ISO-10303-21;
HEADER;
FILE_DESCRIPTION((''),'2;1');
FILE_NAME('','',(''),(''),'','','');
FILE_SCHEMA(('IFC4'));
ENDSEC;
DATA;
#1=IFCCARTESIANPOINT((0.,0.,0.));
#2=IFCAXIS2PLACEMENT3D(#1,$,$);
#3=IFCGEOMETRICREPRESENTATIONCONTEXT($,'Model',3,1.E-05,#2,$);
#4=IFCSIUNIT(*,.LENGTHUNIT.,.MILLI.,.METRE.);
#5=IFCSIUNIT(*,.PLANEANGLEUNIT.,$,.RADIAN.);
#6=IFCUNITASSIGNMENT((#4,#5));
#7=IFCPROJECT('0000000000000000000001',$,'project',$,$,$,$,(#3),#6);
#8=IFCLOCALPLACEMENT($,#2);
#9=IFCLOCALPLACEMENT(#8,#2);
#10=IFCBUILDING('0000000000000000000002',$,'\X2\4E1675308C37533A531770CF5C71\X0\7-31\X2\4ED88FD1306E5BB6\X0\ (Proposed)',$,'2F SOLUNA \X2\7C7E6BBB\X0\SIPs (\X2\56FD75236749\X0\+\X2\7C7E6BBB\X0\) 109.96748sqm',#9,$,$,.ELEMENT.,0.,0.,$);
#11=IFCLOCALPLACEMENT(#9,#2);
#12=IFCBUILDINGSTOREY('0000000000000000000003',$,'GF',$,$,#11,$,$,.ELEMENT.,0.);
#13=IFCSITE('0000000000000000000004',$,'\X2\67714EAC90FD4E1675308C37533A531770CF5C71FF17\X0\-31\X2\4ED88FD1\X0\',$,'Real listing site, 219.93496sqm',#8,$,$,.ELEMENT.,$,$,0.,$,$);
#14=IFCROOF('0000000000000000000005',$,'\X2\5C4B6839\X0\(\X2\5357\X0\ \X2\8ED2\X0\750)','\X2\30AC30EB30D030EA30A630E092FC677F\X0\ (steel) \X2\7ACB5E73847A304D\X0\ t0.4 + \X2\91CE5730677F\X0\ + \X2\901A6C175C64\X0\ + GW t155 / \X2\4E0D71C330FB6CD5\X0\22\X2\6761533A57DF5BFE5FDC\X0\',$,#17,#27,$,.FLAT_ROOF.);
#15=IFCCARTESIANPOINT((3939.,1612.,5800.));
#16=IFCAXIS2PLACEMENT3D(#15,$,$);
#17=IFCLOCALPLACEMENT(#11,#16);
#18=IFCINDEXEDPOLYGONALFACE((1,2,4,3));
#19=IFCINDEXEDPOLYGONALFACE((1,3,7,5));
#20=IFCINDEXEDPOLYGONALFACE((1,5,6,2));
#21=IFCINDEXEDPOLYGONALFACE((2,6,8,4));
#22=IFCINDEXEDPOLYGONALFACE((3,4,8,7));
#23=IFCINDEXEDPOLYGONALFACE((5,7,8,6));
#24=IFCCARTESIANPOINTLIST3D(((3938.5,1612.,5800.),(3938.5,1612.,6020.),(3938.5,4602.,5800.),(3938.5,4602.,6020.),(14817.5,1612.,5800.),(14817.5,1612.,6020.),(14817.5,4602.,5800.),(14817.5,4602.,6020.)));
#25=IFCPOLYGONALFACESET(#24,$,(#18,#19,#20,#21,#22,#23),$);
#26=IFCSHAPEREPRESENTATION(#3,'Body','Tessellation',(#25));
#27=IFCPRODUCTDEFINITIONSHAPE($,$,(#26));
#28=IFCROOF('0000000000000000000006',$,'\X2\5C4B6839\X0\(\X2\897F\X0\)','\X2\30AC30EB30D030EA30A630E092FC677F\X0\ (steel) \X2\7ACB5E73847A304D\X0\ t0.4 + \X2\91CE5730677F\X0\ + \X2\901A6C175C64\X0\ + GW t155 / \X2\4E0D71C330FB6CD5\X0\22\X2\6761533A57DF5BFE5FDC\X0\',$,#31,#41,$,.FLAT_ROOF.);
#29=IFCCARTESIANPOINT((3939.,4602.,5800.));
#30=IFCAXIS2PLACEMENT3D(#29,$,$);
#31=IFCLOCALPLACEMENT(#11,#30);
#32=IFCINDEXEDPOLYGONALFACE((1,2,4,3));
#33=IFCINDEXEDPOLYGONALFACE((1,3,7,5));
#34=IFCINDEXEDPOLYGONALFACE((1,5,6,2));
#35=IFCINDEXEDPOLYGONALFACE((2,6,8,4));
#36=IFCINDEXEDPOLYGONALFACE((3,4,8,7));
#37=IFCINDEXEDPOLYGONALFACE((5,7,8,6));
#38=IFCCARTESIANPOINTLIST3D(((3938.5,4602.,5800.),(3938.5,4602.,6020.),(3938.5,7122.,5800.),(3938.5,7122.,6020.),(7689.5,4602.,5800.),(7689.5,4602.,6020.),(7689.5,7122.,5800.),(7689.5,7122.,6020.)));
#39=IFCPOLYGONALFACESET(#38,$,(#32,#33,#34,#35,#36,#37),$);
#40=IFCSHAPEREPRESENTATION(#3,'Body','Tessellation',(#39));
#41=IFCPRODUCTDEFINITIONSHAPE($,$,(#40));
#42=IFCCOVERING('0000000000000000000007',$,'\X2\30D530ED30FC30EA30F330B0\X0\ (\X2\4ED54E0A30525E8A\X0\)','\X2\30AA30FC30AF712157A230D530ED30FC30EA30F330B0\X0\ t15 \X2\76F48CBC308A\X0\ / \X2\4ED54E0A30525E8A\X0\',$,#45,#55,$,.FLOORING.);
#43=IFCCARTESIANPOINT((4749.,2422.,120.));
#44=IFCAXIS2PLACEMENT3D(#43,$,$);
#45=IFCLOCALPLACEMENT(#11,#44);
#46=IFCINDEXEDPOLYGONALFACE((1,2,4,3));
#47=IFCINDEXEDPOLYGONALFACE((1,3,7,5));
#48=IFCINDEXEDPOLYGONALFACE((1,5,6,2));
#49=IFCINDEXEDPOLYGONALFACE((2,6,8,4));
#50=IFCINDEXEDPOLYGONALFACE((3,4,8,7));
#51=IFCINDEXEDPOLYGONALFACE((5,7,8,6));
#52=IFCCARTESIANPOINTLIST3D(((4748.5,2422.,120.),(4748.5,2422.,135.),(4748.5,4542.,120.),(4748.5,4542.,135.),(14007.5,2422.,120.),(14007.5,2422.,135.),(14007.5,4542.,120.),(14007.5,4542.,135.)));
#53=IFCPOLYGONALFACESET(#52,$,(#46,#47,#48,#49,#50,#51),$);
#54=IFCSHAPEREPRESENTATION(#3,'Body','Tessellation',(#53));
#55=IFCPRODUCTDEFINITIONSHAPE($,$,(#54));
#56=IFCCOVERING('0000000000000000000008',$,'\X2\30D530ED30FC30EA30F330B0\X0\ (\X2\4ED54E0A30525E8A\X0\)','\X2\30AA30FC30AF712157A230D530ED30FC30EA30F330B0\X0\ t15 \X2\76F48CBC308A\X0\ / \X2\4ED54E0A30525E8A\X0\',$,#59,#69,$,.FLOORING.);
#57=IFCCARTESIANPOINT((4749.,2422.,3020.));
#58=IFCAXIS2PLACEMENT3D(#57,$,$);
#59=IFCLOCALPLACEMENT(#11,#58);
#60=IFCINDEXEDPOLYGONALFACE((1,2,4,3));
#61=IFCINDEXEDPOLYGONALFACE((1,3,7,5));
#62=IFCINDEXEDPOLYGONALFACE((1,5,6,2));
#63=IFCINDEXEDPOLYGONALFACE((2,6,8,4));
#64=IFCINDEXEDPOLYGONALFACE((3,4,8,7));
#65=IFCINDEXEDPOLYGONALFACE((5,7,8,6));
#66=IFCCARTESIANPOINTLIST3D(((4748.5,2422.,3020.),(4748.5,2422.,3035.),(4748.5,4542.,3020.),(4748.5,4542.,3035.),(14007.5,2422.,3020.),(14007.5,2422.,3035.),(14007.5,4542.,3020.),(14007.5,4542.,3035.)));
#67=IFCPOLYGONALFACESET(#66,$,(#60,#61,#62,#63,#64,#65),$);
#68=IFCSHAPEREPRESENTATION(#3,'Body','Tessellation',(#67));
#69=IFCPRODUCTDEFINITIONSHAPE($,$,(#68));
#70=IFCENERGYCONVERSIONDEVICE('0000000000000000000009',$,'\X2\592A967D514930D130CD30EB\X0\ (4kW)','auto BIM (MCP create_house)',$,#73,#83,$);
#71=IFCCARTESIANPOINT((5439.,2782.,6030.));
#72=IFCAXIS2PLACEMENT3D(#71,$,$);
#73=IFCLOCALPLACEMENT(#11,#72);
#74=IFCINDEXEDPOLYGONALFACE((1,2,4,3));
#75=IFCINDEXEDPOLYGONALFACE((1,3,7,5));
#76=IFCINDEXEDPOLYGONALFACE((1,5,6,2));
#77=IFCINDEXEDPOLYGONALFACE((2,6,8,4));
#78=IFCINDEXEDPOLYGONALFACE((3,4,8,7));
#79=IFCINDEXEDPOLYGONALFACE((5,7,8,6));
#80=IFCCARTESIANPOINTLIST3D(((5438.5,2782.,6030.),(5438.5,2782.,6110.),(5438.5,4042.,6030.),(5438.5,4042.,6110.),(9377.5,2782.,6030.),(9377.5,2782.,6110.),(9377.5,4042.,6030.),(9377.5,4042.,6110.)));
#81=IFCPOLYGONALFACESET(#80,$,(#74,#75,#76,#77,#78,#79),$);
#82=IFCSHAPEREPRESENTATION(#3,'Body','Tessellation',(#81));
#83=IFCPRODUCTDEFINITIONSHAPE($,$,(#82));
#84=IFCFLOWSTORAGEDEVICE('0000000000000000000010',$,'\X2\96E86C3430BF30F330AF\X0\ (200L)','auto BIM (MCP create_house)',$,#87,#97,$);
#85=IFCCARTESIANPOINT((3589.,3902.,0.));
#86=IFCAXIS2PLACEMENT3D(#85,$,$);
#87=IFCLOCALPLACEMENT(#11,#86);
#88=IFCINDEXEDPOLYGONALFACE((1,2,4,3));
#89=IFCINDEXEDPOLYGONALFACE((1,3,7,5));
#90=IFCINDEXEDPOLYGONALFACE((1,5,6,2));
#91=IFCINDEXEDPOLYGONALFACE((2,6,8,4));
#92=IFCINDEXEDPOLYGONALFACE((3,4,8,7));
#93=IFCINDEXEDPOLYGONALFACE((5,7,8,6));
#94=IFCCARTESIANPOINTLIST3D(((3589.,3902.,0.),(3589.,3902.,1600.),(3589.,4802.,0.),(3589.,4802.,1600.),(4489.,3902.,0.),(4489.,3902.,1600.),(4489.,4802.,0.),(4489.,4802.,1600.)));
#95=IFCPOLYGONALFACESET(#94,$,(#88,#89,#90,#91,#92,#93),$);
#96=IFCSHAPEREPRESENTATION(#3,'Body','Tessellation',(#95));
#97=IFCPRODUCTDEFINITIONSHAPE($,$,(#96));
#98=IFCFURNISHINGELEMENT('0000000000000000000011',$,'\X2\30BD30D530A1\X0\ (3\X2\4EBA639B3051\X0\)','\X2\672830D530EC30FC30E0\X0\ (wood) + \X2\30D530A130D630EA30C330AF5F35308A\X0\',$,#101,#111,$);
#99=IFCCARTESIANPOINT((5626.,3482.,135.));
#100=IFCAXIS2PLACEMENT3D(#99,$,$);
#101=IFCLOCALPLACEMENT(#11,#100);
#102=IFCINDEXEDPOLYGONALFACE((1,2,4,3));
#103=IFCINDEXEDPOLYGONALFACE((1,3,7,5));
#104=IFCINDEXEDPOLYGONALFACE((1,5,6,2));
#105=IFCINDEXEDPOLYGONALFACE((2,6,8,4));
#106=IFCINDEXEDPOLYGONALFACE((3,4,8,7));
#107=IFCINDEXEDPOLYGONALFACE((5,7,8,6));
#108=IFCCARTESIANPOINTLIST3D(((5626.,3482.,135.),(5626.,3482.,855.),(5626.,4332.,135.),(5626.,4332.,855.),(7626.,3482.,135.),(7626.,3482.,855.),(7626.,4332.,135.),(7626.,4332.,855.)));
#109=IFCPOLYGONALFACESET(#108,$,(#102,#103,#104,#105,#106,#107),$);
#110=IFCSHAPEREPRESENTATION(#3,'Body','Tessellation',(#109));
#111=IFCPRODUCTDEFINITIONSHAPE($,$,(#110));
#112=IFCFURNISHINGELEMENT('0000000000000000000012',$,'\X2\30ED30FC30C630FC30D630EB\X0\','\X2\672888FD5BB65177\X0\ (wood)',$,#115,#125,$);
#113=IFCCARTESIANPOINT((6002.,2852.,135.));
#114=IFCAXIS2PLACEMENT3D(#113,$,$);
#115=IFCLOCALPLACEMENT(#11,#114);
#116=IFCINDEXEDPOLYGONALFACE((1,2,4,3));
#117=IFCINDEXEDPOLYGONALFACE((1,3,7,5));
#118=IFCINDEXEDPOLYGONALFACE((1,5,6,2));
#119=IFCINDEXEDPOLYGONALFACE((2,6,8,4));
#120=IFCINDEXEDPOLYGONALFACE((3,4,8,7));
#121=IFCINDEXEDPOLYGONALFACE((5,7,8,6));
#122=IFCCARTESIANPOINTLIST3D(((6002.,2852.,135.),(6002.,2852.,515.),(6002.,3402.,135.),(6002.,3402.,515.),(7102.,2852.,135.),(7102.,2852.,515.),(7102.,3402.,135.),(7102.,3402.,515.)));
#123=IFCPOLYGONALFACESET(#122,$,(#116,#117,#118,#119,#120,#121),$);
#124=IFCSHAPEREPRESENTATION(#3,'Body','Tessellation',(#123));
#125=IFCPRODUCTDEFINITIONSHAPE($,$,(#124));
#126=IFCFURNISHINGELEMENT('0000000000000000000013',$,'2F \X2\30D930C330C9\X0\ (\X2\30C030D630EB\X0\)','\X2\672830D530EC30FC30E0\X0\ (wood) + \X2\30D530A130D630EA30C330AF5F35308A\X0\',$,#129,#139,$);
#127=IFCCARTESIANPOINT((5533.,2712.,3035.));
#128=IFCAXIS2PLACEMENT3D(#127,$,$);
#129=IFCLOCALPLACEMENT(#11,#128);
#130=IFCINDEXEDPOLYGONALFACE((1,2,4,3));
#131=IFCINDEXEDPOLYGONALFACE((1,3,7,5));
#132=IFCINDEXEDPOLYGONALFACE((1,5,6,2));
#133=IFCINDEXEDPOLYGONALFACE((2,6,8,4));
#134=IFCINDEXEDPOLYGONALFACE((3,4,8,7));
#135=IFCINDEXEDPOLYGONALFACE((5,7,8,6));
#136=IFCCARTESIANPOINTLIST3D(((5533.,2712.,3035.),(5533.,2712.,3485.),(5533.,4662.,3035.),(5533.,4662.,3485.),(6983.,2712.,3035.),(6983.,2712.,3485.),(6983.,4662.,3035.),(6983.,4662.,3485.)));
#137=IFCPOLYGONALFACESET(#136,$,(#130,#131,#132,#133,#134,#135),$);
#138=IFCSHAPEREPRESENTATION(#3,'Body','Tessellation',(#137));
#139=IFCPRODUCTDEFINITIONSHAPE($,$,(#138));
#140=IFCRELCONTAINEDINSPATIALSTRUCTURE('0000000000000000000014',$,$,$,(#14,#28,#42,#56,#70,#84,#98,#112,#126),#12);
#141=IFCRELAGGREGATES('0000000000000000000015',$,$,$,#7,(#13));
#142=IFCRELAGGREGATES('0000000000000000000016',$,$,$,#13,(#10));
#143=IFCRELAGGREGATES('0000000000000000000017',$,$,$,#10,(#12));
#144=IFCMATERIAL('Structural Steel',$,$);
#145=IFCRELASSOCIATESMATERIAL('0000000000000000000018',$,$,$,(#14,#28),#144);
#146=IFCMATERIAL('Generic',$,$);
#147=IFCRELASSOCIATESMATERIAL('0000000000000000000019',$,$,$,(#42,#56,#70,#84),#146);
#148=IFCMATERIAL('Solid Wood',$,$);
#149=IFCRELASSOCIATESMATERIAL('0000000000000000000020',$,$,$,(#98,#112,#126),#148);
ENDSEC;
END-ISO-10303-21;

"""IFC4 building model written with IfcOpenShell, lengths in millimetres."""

from ifc_helpers import new_model, si_unit, frame, frame_2d, origin, place, context, project, spatial, rectangle, extrude, material, element, save


model = new_model("IFC4")

# Units and contexts
model_context = context("Model", 3, precision=1e-05, world=origin())
ifc_project = project(units=[si_unit("LENGTHUNIT", "METRE", prefix="MILLI"), si_unit("PLANEANGLEUNIT", "RADIAN")], contexts=[model_context])

# Site, building, storey
site_placement = place(None, origin())
site = spatial("IfcSite", under=ifc_project, at=site_placement, Name="東京都世田谷区北烏山７-31付近", ObjectType="Real listing site, 219.93496sqm", CompositionType="ELEMENT", RefElevation=0.0)
building_placement = place(site_placement, origin())
building = spatial("IfcBuilding", under=site, at=building_placement, Name="世田谷区北烏山7-31付近の家 (Proposed)", ObjectType="2F SOLUNA 籾殻SIPs (国産杉+籾殻) 109.96748sqm", CompositionType="ELEMENT", ElevationOfRefHeight=0.0, ElevationOfTerrain=0.0)
storey_placement = place(building_placement, origin())
storey = spatial("IfcBuildingStorey", under=building, at=storey_placement, Name="GF", CompositionType="ELEMENT", Elevation=0.0)

# Shared definitions
ifc_material_1 = material(Name="Solid Wood")

# Roofs
ifc_material_2 = material(Name="Structural Steel")
roof_1_placement = place(storey_placement, frame((3939.0, 1612.0, 5800.0)))
element("IfcRoof", 1, at=roof_1_placement, inside=storey, material=ifc_material_2, Name="屋根(南 軒750)", Description="ガルバリウム鋼板 (steel) 立平葺き t0.4 + 野地板 + 通気層 + GW t155 / 不燃・法22条区域対応", PredefinedType="FLAT_ROOF", context=model_context, shape_type="SweptSolid", body=[
    extrude(rectangle(XDim=10879.0, YDim=2990.0, at=frame_2d((5439.0, 1495.0))), frame((3939.0, 1612.0, 5800.0)), (0.0, 0.0, 1.0), 220.0),
])
roof_2_placement = place(storey_placement, frame((3939.0, 4602.0, 5800.0)))
element("IfcRoof", 2, at=roof_2_placement, inside=storey, material=ifc_material_2, Name="屋根(西)", Description="ガルバリウム鋼板 (steel) 立平葺き t0.4 + 野地板 + 通気層 + GW t155 / 不燃・法22条区域対応", PredefinedType="FLAT_ROOF", context=model_context, shape_type="SweptSolid", body=[
    extrude(rectangle(XDim=3751.0, YDim=2520.0, at=frame_2d((1875.0, 1260.0))), frame((3939.0, 4602.0, 5800.0)), (0.0, 0.0, 1.0), 220.0),
])

# Coverings
ifc_material_3 = material(Name="Generic")
covering_1_placement = place(storey_placement, frame((4749.0, 2422.0, 120.0)))
element("IfcCovering", 3, at=covering_1_placement, inside=storey, material=ifc_material_3, Name="フローリング (仕上げ床)", Description="オーク無垢フローリング t15 直貼り / 仕上げ床", PredefinedType="FLOORING", context=model_context, shape_type="SweptSolid", body=[
    extrude(rectangle(XDim=9259.0, YDim=2120.0, at=frame_2d((4629.0, 1060.0))), frame((4749.0, 2422.0, 120.0)), (0.0, 0.0, 1.0), 15.0),
])
covering_2_placement = place(storey_placement, frame((4749.0, 2422.0, 3020.0)))
element("IfcCovering", 4, at=covering_2_placement, inside=storey, material=ifc_material_3, Name="フローリング (仕上げ床)", Description="オーク無垢フローリング t15 直貼り / 仕上げ床", PredefinedType="FLOORING", context=model_context, shape_type="SweptSolid", body=[
    extrude(rectangle(XDim=9259.0, YDim=2120.0, at=frame_2d((4629.0, 1060.0))), frame((4749.0, 2422.0, 3020.0)), (0.0, 0.0, 1.0), 15.0),
])

# Energy conversion device
energy_conversion_device_placement = place(storey_placement, frame((5439.0, 2782.0, 6030.0)))
element("IfcEnergyConversionDevice", 5, at=energy_conversion_device_placement, inside=storey, material=ifc_material_3, Name="太陽光パネル (4kW)", Description="auto BIM (MCP create_house)", context=model_context, shape_type="SweptSolid", body=[
    extrude(rectangle(XDim=3939.0, YDim=1260.0, at=frame_2d((1969.0, 630.0))), frame((5439.0, 2782.0, 6030.0)), (0.0, 0.0, 1.0), 80.0),
])

# Flow storage device
flow_storage_device_placement = place(storey_placement, frame((3589.0, 3902.0, 0.0)))
element("IfcFlowStorageDevice", 6, at=flow_storage_device_placement, inside=storey, material=ifc_material_3, Name="雨水タンク (200L)", Description="auto BIM (MCP create_house)", context=model_context, shape_type="SweptSolid", body=[
    extrude(rectangle(XDim=900.0, YDim=900.0, at=frame_2d((450.0, 450.0))), frame((3589.0, 3902.0, 0.0)), (0.0, 0.0, 1.0), 1600.0),
])

# Furnishing elements
furnishing_1_placement = place(storey_placement, frame((5626.0, 3482.0, 135.0)))
element("IfcFurnishingElement", 7, at=furnishing_1_placement, inside=storey, material=ifc_material_1, Name="ソファ (3人掛け)", Description="木フレーム (wood) + ファブリック張り", context=model_context, shape_type="SweptSolid", body=[
    extrude(rectangle(XDim=2000.0, YDim=850.0, at=frame_2d((1000.0, 425.0))), frame((5626.0, 3482.0, 135.0)), (0.0, 0.0, 1.0), 720.0),
])
furnishing_2_placement = place(storey_placement, frame((6002.0, 2852.0, 135.0)))
element("IfcFurnishingElement", 8, at=furnishing_2_placement, inside=storey, material=ifc_material_1, Name="ローテーブル", Description="木製家具 (wood)", context=model_context, shape_type="SweptSolid", body=[
    extrude(rectangle(XDim=1100.0, YDim=550.0, at=frame_2d((550.0, 275.0))), frame((6002.0, 2852.0, 135.0)), (0.0, 0.0, 1.0), 380.0),
])
furnishing_3_placement = place(storey_placement, frame((5533.0, 2712.0, 3035.0)))
element("IfcFurnishingElement", 9, at=furnishing_3_placement, inside=storey, material=ifc_material_1, Name="2F ベッド (ダブル)", Description="木フレーム (wood) + ファブリック張り", context=model_context, shape_type="SweptSolid", body=[
    extrude(rectangle(XDim=1450.0, YDim=1950.0, at=frame_2d((725.0, 975.0))), frame((5533.0, 2712.0, 3035.0)), (0.0, 0.0, 1.0), 450.0),
])

save(model, "model.ifc")
